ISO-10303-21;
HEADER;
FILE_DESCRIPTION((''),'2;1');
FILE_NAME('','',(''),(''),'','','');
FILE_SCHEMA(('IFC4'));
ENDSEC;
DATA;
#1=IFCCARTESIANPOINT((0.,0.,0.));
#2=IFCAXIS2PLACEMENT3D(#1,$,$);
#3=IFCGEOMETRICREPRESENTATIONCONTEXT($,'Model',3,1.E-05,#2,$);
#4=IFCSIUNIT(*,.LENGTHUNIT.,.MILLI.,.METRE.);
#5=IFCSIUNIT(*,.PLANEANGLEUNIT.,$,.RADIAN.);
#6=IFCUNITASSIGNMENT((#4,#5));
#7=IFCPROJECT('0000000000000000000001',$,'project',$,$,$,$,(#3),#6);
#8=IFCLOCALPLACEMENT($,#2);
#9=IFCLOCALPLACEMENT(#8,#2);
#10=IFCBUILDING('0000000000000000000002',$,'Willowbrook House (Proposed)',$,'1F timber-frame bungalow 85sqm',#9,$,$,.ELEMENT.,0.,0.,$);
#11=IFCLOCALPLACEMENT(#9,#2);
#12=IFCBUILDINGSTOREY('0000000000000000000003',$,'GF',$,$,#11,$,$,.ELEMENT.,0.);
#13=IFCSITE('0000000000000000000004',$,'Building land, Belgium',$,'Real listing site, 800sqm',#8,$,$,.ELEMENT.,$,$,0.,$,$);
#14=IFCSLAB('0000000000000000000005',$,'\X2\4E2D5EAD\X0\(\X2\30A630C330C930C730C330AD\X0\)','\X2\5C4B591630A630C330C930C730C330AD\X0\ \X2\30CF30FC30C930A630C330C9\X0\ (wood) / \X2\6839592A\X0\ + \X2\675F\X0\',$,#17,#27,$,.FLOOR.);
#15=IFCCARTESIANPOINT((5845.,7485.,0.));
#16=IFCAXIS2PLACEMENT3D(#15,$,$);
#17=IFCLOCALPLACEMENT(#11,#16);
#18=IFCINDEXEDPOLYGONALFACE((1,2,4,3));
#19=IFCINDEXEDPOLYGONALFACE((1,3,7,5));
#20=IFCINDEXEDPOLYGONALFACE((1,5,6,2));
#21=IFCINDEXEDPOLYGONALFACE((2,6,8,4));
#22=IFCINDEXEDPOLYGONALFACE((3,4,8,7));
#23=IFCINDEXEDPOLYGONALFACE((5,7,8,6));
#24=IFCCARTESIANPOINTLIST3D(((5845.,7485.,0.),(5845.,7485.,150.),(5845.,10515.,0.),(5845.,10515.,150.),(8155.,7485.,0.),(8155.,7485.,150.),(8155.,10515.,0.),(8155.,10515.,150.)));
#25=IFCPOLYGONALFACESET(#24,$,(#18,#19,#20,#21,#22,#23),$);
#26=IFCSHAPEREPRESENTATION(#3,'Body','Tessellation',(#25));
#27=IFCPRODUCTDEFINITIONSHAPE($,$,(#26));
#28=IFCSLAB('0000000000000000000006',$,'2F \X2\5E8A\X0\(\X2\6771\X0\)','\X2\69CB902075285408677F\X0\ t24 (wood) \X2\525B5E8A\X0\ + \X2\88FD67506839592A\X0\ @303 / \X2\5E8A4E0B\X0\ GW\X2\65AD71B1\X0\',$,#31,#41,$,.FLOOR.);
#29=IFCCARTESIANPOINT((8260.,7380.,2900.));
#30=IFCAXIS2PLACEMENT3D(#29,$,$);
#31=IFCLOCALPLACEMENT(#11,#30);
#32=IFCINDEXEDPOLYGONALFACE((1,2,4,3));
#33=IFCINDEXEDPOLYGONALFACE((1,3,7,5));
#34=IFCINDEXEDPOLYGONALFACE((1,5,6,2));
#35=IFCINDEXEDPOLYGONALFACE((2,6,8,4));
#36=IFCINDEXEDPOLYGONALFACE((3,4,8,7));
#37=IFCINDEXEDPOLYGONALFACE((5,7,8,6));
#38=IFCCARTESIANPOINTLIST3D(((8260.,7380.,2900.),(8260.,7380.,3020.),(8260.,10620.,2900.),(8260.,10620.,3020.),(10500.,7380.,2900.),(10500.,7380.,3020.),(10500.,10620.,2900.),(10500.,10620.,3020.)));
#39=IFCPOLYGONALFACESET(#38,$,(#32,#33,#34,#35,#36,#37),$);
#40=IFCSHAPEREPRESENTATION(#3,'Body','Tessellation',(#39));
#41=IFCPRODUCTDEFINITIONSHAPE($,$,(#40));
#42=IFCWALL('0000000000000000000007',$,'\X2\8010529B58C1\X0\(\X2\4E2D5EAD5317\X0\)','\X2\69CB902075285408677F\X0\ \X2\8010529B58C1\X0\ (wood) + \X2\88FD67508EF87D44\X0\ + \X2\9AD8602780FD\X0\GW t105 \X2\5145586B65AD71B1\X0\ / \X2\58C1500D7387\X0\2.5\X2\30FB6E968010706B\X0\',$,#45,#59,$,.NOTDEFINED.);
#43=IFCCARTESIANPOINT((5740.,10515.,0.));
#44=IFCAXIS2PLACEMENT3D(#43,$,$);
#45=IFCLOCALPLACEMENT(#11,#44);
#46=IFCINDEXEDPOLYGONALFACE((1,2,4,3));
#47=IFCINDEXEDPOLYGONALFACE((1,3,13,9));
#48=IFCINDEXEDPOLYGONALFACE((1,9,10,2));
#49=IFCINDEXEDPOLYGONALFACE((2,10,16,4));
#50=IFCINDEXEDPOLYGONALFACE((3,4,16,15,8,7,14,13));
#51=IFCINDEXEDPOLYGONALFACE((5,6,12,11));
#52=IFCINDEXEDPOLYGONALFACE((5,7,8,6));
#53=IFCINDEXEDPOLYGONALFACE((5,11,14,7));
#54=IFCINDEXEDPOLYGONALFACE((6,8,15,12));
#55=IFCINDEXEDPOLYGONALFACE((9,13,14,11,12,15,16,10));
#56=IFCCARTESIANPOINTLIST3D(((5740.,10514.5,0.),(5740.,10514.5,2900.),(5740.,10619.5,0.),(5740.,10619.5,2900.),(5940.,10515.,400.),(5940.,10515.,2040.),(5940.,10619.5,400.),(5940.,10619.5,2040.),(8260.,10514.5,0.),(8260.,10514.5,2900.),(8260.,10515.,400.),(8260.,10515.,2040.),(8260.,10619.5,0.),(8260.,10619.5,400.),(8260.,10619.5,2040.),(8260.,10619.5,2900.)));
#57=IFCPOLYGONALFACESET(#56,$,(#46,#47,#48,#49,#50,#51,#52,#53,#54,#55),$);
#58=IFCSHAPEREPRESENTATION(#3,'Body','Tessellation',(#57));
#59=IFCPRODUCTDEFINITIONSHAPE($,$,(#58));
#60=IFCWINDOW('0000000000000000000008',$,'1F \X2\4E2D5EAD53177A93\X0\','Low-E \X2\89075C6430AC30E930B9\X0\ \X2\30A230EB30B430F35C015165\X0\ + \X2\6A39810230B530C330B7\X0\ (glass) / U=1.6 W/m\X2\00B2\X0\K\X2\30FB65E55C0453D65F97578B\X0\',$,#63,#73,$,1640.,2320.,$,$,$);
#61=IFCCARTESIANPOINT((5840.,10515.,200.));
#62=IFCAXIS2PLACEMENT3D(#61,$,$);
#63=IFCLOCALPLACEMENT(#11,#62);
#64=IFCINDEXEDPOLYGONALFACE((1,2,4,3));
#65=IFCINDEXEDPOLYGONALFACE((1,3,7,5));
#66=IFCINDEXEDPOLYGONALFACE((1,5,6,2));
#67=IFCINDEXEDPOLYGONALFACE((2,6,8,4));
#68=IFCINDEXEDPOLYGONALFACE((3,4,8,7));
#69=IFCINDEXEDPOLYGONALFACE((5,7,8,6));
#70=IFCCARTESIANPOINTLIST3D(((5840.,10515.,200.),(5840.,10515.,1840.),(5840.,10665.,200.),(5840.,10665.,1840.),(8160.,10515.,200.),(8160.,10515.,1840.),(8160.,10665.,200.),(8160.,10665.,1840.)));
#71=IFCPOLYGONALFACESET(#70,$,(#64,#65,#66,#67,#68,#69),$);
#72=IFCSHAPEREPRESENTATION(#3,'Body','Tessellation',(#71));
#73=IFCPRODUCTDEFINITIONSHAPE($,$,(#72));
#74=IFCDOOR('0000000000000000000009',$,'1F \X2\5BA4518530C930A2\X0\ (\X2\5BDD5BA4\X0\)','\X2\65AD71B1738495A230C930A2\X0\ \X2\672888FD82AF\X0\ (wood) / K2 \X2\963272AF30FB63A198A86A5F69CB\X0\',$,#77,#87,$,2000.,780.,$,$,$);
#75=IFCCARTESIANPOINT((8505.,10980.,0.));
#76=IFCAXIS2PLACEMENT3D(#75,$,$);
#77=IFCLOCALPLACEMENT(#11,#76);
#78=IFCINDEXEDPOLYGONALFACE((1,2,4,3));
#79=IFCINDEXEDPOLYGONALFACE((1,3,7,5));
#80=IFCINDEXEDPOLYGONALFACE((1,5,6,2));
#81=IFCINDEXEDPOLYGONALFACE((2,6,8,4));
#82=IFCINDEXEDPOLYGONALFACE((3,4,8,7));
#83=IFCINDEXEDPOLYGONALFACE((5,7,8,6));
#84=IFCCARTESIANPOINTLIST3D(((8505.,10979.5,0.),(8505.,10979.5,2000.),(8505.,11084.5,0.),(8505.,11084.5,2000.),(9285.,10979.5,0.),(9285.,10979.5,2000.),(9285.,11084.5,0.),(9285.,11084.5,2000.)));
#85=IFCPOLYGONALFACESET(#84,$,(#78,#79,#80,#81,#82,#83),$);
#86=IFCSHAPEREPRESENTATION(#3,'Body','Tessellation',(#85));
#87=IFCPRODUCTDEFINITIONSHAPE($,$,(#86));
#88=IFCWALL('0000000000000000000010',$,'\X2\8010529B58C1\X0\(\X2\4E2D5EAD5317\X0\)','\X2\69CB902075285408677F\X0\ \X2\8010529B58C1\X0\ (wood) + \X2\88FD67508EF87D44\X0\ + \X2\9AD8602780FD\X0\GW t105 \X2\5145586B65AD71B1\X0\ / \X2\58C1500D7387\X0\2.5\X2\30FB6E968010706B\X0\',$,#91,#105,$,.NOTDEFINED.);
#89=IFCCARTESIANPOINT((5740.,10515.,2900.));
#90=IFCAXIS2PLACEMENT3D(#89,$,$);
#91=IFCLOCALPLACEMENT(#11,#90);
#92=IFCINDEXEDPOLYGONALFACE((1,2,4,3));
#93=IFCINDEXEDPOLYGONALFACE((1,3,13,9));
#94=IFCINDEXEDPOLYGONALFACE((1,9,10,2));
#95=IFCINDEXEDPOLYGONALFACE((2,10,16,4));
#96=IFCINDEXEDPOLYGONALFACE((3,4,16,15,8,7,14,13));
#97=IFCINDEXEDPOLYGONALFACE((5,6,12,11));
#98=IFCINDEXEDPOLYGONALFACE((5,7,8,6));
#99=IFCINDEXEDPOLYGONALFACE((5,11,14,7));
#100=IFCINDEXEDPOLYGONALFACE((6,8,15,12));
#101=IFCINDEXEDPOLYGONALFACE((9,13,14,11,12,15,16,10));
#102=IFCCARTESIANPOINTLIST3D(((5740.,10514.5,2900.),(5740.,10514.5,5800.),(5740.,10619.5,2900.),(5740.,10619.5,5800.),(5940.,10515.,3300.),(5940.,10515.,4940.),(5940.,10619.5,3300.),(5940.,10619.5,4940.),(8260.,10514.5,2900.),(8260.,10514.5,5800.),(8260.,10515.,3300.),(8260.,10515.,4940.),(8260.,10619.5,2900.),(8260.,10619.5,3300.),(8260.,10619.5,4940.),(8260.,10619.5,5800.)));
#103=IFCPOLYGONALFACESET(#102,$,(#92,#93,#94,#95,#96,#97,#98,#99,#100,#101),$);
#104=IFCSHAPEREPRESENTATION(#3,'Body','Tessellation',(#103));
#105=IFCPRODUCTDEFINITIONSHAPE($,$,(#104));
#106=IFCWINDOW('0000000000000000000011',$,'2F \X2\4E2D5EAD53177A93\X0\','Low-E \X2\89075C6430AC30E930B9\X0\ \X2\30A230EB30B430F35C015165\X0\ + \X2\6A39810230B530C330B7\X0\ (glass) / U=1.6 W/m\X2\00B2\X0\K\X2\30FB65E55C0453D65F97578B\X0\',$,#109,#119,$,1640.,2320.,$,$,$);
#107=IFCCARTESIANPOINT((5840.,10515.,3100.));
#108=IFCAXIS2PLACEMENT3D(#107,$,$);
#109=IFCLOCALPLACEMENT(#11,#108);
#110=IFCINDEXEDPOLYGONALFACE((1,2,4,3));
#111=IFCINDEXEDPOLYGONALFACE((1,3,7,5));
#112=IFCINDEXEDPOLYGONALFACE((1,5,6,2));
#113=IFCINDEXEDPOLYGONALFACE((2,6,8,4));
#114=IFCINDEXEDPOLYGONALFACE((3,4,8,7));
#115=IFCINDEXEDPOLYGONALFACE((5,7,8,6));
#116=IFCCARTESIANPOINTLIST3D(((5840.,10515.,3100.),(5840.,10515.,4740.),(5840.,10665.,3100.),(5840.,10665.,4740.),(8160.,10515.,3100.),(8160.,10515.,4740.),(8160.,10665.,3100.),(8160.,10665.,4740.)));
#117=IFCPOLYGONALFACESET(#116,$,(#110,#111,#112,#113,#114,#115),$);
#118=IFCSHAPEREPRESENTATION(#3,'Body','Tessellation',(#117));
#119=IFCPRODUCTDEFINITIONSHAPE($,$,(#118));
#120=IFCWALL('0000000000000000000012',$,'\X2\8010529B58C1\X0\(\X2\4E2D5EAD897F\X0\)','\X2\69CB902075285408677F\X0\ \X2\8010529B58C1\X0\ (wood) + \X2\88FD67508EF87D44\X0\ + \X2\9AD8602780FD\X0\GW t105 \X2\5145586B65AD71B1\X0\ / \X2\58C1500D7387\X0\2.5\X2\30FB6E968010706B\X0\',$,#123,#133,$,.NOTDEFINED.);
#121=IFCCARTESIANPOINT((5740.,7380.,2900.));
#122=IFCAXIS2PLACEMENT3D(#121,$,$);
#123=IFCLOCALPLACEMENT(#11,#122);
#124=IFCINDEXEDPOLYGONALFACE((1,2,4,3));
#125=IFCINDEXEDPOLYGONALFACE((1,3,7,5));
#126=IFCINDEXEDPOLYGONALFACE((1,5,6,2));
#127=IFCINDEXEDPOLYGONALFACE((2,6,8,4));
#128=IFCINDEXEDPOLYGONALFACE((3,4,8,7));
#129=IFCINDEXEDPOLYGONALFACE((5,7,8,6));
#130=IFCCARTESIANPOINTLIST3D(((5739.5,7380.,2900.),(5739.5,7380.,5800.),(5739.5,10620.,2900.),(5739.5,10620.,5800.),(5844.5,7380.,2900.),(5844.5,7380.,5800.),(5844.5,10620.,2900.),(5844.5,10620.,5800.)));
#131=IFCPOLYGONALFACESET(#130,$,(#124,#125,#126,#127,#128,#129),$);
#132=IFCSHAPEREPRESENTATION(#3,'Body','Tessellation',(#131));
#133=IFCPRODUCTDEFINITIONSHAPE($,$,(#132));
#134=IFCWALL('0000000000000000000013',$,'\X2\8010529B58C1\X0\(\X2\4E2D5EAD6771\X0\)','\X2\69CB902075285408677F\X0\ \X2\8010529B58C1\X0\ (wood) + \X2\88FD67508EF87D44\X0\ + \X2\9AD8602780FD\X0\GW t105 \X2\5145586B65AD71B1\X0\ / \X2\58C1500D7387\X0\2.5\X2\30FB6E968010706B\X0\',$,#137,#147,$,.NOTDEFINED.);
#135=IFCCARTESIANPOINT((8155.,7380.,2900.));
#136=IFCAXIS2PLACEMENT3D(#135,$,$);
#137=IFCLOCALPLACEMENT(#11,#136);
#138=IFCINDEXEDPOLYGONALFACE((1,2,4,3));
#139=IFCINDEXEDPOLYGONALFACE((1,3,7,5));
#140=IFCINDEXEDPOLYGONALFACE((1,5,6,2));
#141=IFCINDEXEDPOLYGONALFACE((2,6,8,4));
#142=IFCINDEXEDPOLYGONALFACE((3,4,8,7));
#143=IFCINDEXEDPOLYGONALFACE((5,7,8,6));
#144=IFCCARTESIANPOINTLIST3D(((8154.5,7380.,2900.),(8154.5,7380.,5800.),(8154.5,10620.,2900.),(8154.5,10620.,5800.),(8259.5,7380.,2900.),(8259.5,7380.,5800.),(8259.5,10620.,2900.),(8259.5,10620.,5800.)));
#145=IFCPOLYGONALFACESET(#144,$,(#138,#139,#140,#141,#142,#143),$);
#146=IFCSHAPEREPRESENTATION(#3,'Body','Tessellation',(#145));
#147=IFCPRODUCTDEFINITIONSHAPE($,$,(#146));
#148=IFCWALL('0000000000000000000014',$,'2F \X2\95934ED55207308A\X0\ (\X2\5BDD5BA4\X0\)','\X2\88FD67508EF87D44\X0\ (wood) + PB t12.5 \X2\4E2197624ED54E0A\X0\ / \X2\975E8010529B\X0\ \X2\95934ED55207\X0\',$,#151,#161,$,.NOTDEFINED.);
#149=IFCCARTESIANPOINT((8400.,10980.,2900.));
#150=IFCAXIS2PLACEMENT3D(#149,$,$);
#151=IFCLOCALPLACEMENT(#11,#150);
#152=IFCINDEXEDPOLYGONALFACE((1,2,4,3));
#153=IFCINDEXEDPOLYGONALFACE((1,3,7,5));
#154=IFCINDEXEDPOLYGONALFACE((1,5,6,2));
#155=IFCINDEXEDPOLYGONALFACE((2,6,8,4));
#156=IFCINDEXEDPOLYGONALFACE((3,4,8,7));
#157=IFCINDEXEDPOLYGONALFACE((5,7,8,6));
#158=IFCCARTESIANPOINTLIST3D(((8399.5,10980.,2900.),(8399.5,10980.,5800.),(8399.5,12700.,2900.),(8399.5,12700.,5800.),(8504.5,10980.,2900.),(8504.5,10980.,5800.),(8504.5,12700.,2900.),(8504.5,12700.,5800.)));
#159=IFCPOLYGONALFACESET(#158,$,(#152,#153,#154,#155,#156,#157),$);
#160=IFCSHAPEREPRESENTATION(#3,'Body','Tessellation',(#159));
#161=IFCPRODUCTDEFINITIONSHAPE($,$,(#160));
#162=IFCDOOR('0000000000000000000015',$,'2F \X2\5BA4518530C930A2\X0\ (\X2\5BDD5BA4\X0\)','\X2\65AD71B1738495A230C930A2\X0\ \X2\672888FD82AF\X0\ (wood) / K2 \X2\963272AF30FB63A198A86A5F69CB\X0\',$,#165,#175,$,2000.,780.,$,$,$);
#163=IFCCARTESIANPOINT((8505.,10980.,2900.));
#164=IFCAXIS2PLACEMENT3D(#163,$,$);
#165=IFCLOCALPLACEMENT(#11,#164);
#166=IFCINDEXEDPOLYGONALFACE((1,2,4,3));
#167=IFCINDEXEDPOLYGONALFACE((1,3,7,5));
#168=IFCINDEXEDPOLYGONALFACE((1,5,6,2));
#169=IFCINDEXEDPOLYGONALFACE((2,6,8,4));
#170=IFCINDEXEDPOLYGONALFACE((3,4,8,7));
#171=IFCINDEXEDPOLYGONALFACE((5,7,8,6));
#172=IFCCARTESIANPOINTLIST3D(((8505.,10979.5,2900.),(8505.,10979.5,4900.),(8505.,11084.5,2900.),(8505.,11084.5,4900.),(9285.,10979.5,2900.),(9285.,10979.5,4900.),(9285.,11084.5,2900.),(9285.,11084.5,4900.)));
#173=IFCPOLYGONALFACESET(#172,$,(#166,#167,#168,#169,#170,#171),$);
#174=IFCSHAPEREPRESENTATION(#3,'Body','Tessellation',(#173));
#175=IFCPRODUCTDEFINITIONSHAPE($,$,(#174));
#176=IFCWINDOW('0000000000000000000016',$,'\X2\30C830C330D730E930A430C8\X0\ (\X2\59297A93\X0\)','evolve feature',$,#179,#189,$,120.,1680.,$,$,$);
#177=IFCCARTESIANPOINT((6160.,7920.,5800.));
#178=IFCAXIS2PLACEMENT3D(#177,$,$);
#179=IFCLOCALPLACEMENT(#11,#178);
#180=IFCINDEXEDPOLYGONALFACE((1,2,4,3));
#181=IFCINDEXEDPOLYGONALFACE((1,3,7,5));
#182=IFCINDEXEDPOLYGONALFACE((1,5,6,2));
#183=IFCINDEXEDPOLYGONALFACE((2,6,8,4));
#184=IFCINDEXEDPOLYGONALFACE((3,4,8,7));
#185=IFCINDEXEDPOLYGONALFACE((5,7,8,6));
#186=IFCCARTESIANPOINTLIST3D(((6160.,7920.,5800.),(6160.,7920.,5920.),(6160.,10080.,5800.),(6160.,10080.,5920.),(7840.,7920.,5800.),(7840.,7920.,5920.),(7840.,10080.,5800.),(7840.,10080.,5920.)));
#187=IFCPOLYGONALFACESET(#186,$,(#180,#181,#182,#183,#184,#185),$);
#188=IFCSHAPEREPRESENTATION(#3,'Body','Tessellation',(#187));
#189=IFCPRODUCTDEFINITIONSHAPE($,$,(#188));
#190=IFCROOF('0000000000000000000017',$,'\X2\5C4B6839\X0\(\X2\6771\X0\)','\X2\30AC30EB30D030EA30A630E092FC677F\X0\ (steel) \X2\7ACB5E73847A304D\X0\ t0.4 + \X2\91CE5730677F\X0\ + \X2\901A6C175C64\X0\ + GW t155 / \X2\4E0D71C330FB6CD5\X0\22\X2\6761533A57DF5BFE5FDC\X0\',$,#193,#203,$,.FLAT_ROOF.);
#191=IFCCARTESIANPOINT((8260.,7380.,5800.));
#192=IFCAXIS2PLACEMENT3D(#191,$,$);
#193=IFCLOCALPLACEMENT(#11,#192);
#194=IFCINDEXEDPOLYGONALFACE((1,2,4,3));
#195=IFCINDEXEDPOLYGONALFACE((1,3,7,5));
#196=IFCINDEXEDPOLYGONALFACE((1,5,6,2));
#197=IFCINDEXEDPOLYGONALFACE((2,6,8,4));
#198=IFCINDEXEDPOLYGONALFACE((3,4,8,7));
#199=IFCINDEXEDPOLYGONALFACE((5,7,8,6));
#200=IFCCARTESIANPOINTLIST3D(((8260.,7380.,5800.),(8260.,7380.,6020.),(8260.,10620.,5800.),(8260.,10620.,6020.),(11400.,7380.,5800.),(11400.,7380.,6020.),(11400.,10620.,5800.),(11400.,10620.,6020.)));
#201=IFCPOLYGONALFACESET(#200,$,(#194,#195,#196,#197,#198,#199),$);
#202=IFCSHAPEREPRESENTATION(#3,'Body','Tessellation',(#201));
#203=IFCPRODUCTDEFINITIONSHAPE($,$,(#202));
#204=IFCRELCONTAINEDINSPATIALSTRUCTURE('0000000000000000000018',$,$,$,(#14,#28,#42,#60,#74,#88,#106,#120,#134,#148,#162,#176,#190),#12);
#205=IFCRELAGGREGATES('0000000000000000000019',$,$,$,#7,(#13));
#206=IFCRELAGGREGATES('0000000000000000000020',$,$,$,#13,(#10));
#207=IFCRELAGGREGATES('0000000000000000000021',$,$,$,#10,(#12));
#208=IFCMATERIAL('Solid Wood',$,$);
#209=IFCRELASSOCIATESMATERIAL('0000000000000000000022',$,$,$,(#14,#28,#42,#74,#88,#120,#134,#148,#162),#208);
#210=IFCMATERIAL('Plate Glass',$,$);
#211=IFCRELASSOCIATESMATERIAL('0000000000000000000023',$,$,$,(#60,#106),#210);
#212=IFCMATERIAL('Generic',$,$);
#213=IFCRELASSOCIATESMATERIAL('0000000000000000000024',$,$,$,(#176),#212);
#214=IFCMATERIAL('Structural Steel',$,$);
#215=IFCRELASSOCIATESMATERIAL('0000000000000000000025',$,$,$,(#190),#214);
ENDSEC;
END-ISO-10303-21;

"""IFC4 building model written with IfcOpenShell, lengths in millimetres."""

from ifc_helpers import new_model, si_unit, frame, frame_2d, origin, place, context, project, spatial, rectangle, extrude, material, element, fill, save


model = new_model("IFC4")

# Units and contexts
model_context = context("Model", 3, precision=1e-05, world=origin())
ifc_project = project(units=[si_unit("LENGTHUNIT", "METRE", prefix="MILLI"), si_unit("PLANEANGLEUNIT", "RADIAN")], contexts=[model_context])

# Site, building, storey
site_placement = place(None, origin())
site = spatial("IfcSite", under=ifc_project, at=site_placement, Name="Building land, Belgium", ObjectType="Real listing site, 800sqm", CompositionType="ELEMENT", RefElevation=0.0)
building_placement = place(site_placement, origin())
building = spatial("IfcBuilding", under=site, at=building_placement, Name="Willowbrook House (Proposed)", ObjectType="1F timber-frame bungalow 85sqm", CompositionType="ELEMENT", ElevationOfRefHeight=0.0, ElevationOfTerrain=0.0)
storey_placement = place(building_placement, origin())
storey = spatial("IfcBuildingStorey", under=building, at=storey_placement, Name="GF", CompositionType="ELEMENT", Elevation=0.0)

# Slabs
ifc_material_1 = material(Name="Solid Wood")
slab_1_placement = place(storey_placement, frame((5845.0, 7485.0, 0.0)))
element("IfcSlab", 1, at=slab_1_placement, inside=storey, material=ifc_material_1, Name="中庭(ウッドデッキ)", Description="屋外ウッドデッキ ハードウッド (wood) / 根太 + 束", PredefinedType="FLOOR", context=model_context, shape_type="SweptSolid", body=[
    extrude(rectangle(XDim=2310.0, YDim=3030.0, at=frame_2d((1155.0, 1515.0))), frame((5845.0, 7485.0, 0.0)), (0.0, 0.0, 1.0), 150.0),
])
slab_2_placement = place(storey_placement, frame((8260.0, 7380.0, 2900.0)))
element("IfcSlab", 2, at=slab_2_placement, inside=storey, material=ifc_material_1, Name="2F 床(東)", Description="構造用合板 t24 (wood) 剛床 + 製材根太 @303 / 床下 GW断熱", PredefinedType="FLOOR", context=model_context, shape_type="SweptSolid", body=[
    extrude(rectangle(XDim=2240.0, YDim=3240.0, at=frame_2d((1120.0, 1620.0))), frame((8260.0, 7380.0, 2900.0)), (0.0, 0.0, 1.0), 120.0),
])

# Wall, opening, window
wall_1_placement = place(storey_placement, frame((5740.0, 10515.0, 0.0)))
wall_1 = element("IfcWall", 3, at=wall_1_placement, inside=storey, material=ifc_material_1, Name="耐力壁(中庭北)", Description="構造用合板 耐力壁 (wood) + 製材軸組 + 高性能GW t105 充填断熱 / 壁倍率2.5・準耐火", PredefinedType="NOTDEFINED", context=model_context, shape_type="SweptSolid", body=[
    extrude(rectangle(XDim=2520.0, YDim=105.0, at=frame_2d((1260.0, 52.0))), frame((5740.0, 10515.0, 0.0)), (0.0, 0.0, 1.0), 2900.0),
])
opening_1_placement = place(storey_placement, frame((5840.0, 10515.0, 200.0)))
opening_1 = element("IfcOpeningElement", 4, at=opening_1_placement, cuts=wall_1, PredefinedType="NOTDEFINED", context=model_context, shape_type="SweptSolid", body=[
    extrude(rectangle(XDim=2320.0, YDim=150.0, at=frame_2d((1160.0, 75.0))), frame((5840.0, 10515.0, 200.0)), (0.0, 0.0, 1.0), 1640.0),
])
ifc_material_2 = material(Name="Plate Glass")
window_1_placement = place(storey_placement, frame((5840.0, 10515.0, 200.0)))
window_1 = element("IfcWindow", 5, at=window_1_placement, inside=storey, material=ifc_material_2, Name="1F 中庭北窓", Description="Low-E 複層ガラス アルゴン封入 + 樹脂サッシ (glass) / U=1.6 W/m²K・日射取得型", OverallHeight=1640.0, OverallWidth=2320.0, context=model_context, shape_type="SweptSolid", body=[
    extrude(rectangle(XDim=2320.0, YDim=150.0, at=frame_2d((1160.0, 75.0))), frame((5840.0, 10515.0, 200.0)), (0.0, 0.0, 1.0), 1640.0),
])
fill(opening_1, window_1)

# Door
door_1_placement = place(storey_placement, frame((8505.0, 10980.0, 0.0)))
element("IfcDoor", 6, at=door_1_placement, inside=storey, material=ifc_material_1, Name="1F 室内ドア (寝室)", Description="断熱玄関ドア 木製芯 (wood) / K2 防犯・採風機構", OverallHeight=2000.0, OverallWidth=780.0, context=model_context, shape_type="SweptSolid", body=[
    extrude(rectangle(XDim=780.0, YDim=105.0, at=frame_2d((390.0, 52.0))), frame((8505.0, 10980.0, 0.0)), (0.0, 0.0, 1.0), 2000.0),
])

# Wall, opening, window
wall_2_placement = place(storey_placement, frame((5740.0, 10515.0, 2900.0)))
wall_2 = element("IfcWall", 7, at=wall_2_placement, inside=storey, material=ifc_material_1, Name="耐力壁(中庭北)", Description="構造用合板 耐力壁 (wood) + 製材軸組 + 高性能GW t105 充填断熱 / 壁倍率2.5・準耐火", PredefinedType="NOTDEFINED", context=model_context, shape_type="SweptSolid", body=[
    extrude(rectangle(XDim=2520.0, YDim=105.0, at=frame_2d((1260.0, 52.0))), frame((5740.0, 10515.0, 2900.0)), (0.0, 0.0, 1.0), 2900.0),
])
opening_2_placement = place(storey_placement, frame((5840.0, 10515.0, 3100.0)))
opening_2 = element("IfcOpeningElement", 8, at=opening_2_placement, cuts=wall_2, PredefinedType="NOTDEFINED", context=model_context, shape_type="SweptSolid", body=[
    extrude(rectangle(XDim=2320.0, YDim=150.0, at=frame_2d((1160.0, 75.0))), frame((5840.0, 10515.0, 3100.0)), (0.0, 0.0, 1.0), 1640.0),
])
window_2_placement = place(storey_placement, frame((5840.0, 10515.0, 3100.0)))
window_2 = element("IfcWindow", 9, at=window_2_placement, inside=storey, material=ifc_material_2, Name="2F 中庭北窓", Description="Low-E 複層ガラス アルゴン封入 + 樹脂サッシ (glass) / U=1.6 W/m²K・日射取得型", OverallHeight=1640.0, OverallWidth=2320.0, context=model_context, shape_type="SweptSolid", body=[
    extrude(rectangle(XDim=2320.0, YDim=150.0, at=frame_2d((1160.0, 75.0))), frame((5840.0, 10515.0, 3100.0)), (0.0, 0.0, 1.0), 1640.0),
])
fill(opening_2, window_2)

# Walls
wall_3_placement = place(storey_placement, frame((5740.0, 7380.0, 2900.0)))
element("IfcWall", 10, at=wall_3_placement, inside=storey, material=ifc_material_1, Name="耐力壁(中庭西)", Description="構造用合板 耐力壁 (wood) + 製材軸組 + 高性能GW t105 充填断熱 / 壁倍率2.5・準耐火", PredefinedType="NOTDEFINED", context=model_context, shape_type="SweptSolid", body=[
    extrude(rectangle(XDim=105.0, YDim=3240.0, at=frame_2d((52.0, 1620.0))), frame((5740.0, 7380.0, 2900.0)), (0.0, 0.0, 1.0), 2900.0),
])
wall_4_placement = place(storey_placement, frame((8155.0, 7380.0, 2900.0)))
element("IfcWall", 11, at=wall_4_placement, inside=storey, material=ifc_material_1, Name="耐力壁(中庭東)", Description="構造用合板 耐力壁 (wood) + 製材軸組 + 高性能GW t105 充填断熱 / 壁倍率2.5・準耐火", PredefinedType="NOTDEFINED", context=model_context, shape_type="SweptSolid", body=[
    extrude(rectangle(XDim=105.0, YDim=3240.0, at=frame_2d((52.0, 1620.0))), frame((8155.0, 7380.0, 2900.0)), (0.0, 0.0, 1.0), 2900.0),
])
wall_5_placement = place(storey_placement, frame((8400.0, 10980.0, 2900.0)))
element("IfcWall", 12, at=wall_5_placement, inside=storey, material=ifc_material_1, Name="2F 間仕切り (寝室)", Description="製材軸組 (wood) + PB t12.5 両面仕上 / 非耐力 間仕切", PredefinedType="NOTDEFINED", context=model_context, shape_type="SweptSolid", body=[
    extrude(rectangle(XDim=105.0, YDim=1720.0, at=frame_2d((52.0, 860.0))), frame((8400.0, 10980.0, 2900.0)), (0.0, 0.0, 1.0), 2900.0),
])

# Door
door_2_placement = place(storey_placement, frame((8505.0, 10980.0, 2900.0)))
element("IfcDoor", 13, at=door_2_placement, inside=storey, material=ifc_material_1, Name="2F 室内ドア (寝室)", Description="断熱玄関ドア 木製芯 (wood) / K2 防犯・採風機構", OverallHeight=2000.0, OverallWidth=780.0, context=model_context, shape_type="SweptSolid", body=[
    extrude(rectangle(XDim=780.0, YDim=105.0, at=frame_2d((390.0, 52.0))), frame((8505.0, 10980.0, 2900.0)), (0.0, 0.0, 1.0), 2000.0),
])

# Window
ifc_material_3 = material(Name="Generic")
window_3_placement = place(storey_placement, frame((6160.0, 7920.0, 5800.0)))
element("IfcWindow", 14, at=window_3_placement, inside=storey, material=ifc_material_3, Name="トップライト (天窓)", Description="evolve feature", OverallHeight=120.0, OverallWidth=1680.0, context=model_context, shape_type="SweptSolid", body=[
    extrude(rectangle(XDim=1680.0, YDim=2160.0, at=frame_2d((840.0, 1080.0))), frame((6160.0, 7920.0, 5800.0)), (0.0, 0.0, 1.0), 120.0),
])

# Roof
ifc_material_4 = material(Name="Structural Steel")
roof_placement = place(storey_placement, frame((8260.0, 7380.0, 5800.0)))
element("IfcRoof", 15, at=roof_placement, inside=storey, material=ifc_material_4, Name="屋根(東)", Description="ガルバリウム鋼板 (steel) 立平葺き t0.4 + 野地板 + 通気層 + GW t155 / 不燃・法22条区域対応", PredefinedType="FLAT_ROOF", context=model_context, shape_type="SweptSolid", body=[
    extrude(rectangle(XDim=3140.0, YDim=3240.0, at=frame_2d((1570.0, 1620.0))), frame((8260.0, 7380.0, 5800.0)), (0.0, 0.0, 1.0), 220.0),
])

save(model, "model.ifc")
